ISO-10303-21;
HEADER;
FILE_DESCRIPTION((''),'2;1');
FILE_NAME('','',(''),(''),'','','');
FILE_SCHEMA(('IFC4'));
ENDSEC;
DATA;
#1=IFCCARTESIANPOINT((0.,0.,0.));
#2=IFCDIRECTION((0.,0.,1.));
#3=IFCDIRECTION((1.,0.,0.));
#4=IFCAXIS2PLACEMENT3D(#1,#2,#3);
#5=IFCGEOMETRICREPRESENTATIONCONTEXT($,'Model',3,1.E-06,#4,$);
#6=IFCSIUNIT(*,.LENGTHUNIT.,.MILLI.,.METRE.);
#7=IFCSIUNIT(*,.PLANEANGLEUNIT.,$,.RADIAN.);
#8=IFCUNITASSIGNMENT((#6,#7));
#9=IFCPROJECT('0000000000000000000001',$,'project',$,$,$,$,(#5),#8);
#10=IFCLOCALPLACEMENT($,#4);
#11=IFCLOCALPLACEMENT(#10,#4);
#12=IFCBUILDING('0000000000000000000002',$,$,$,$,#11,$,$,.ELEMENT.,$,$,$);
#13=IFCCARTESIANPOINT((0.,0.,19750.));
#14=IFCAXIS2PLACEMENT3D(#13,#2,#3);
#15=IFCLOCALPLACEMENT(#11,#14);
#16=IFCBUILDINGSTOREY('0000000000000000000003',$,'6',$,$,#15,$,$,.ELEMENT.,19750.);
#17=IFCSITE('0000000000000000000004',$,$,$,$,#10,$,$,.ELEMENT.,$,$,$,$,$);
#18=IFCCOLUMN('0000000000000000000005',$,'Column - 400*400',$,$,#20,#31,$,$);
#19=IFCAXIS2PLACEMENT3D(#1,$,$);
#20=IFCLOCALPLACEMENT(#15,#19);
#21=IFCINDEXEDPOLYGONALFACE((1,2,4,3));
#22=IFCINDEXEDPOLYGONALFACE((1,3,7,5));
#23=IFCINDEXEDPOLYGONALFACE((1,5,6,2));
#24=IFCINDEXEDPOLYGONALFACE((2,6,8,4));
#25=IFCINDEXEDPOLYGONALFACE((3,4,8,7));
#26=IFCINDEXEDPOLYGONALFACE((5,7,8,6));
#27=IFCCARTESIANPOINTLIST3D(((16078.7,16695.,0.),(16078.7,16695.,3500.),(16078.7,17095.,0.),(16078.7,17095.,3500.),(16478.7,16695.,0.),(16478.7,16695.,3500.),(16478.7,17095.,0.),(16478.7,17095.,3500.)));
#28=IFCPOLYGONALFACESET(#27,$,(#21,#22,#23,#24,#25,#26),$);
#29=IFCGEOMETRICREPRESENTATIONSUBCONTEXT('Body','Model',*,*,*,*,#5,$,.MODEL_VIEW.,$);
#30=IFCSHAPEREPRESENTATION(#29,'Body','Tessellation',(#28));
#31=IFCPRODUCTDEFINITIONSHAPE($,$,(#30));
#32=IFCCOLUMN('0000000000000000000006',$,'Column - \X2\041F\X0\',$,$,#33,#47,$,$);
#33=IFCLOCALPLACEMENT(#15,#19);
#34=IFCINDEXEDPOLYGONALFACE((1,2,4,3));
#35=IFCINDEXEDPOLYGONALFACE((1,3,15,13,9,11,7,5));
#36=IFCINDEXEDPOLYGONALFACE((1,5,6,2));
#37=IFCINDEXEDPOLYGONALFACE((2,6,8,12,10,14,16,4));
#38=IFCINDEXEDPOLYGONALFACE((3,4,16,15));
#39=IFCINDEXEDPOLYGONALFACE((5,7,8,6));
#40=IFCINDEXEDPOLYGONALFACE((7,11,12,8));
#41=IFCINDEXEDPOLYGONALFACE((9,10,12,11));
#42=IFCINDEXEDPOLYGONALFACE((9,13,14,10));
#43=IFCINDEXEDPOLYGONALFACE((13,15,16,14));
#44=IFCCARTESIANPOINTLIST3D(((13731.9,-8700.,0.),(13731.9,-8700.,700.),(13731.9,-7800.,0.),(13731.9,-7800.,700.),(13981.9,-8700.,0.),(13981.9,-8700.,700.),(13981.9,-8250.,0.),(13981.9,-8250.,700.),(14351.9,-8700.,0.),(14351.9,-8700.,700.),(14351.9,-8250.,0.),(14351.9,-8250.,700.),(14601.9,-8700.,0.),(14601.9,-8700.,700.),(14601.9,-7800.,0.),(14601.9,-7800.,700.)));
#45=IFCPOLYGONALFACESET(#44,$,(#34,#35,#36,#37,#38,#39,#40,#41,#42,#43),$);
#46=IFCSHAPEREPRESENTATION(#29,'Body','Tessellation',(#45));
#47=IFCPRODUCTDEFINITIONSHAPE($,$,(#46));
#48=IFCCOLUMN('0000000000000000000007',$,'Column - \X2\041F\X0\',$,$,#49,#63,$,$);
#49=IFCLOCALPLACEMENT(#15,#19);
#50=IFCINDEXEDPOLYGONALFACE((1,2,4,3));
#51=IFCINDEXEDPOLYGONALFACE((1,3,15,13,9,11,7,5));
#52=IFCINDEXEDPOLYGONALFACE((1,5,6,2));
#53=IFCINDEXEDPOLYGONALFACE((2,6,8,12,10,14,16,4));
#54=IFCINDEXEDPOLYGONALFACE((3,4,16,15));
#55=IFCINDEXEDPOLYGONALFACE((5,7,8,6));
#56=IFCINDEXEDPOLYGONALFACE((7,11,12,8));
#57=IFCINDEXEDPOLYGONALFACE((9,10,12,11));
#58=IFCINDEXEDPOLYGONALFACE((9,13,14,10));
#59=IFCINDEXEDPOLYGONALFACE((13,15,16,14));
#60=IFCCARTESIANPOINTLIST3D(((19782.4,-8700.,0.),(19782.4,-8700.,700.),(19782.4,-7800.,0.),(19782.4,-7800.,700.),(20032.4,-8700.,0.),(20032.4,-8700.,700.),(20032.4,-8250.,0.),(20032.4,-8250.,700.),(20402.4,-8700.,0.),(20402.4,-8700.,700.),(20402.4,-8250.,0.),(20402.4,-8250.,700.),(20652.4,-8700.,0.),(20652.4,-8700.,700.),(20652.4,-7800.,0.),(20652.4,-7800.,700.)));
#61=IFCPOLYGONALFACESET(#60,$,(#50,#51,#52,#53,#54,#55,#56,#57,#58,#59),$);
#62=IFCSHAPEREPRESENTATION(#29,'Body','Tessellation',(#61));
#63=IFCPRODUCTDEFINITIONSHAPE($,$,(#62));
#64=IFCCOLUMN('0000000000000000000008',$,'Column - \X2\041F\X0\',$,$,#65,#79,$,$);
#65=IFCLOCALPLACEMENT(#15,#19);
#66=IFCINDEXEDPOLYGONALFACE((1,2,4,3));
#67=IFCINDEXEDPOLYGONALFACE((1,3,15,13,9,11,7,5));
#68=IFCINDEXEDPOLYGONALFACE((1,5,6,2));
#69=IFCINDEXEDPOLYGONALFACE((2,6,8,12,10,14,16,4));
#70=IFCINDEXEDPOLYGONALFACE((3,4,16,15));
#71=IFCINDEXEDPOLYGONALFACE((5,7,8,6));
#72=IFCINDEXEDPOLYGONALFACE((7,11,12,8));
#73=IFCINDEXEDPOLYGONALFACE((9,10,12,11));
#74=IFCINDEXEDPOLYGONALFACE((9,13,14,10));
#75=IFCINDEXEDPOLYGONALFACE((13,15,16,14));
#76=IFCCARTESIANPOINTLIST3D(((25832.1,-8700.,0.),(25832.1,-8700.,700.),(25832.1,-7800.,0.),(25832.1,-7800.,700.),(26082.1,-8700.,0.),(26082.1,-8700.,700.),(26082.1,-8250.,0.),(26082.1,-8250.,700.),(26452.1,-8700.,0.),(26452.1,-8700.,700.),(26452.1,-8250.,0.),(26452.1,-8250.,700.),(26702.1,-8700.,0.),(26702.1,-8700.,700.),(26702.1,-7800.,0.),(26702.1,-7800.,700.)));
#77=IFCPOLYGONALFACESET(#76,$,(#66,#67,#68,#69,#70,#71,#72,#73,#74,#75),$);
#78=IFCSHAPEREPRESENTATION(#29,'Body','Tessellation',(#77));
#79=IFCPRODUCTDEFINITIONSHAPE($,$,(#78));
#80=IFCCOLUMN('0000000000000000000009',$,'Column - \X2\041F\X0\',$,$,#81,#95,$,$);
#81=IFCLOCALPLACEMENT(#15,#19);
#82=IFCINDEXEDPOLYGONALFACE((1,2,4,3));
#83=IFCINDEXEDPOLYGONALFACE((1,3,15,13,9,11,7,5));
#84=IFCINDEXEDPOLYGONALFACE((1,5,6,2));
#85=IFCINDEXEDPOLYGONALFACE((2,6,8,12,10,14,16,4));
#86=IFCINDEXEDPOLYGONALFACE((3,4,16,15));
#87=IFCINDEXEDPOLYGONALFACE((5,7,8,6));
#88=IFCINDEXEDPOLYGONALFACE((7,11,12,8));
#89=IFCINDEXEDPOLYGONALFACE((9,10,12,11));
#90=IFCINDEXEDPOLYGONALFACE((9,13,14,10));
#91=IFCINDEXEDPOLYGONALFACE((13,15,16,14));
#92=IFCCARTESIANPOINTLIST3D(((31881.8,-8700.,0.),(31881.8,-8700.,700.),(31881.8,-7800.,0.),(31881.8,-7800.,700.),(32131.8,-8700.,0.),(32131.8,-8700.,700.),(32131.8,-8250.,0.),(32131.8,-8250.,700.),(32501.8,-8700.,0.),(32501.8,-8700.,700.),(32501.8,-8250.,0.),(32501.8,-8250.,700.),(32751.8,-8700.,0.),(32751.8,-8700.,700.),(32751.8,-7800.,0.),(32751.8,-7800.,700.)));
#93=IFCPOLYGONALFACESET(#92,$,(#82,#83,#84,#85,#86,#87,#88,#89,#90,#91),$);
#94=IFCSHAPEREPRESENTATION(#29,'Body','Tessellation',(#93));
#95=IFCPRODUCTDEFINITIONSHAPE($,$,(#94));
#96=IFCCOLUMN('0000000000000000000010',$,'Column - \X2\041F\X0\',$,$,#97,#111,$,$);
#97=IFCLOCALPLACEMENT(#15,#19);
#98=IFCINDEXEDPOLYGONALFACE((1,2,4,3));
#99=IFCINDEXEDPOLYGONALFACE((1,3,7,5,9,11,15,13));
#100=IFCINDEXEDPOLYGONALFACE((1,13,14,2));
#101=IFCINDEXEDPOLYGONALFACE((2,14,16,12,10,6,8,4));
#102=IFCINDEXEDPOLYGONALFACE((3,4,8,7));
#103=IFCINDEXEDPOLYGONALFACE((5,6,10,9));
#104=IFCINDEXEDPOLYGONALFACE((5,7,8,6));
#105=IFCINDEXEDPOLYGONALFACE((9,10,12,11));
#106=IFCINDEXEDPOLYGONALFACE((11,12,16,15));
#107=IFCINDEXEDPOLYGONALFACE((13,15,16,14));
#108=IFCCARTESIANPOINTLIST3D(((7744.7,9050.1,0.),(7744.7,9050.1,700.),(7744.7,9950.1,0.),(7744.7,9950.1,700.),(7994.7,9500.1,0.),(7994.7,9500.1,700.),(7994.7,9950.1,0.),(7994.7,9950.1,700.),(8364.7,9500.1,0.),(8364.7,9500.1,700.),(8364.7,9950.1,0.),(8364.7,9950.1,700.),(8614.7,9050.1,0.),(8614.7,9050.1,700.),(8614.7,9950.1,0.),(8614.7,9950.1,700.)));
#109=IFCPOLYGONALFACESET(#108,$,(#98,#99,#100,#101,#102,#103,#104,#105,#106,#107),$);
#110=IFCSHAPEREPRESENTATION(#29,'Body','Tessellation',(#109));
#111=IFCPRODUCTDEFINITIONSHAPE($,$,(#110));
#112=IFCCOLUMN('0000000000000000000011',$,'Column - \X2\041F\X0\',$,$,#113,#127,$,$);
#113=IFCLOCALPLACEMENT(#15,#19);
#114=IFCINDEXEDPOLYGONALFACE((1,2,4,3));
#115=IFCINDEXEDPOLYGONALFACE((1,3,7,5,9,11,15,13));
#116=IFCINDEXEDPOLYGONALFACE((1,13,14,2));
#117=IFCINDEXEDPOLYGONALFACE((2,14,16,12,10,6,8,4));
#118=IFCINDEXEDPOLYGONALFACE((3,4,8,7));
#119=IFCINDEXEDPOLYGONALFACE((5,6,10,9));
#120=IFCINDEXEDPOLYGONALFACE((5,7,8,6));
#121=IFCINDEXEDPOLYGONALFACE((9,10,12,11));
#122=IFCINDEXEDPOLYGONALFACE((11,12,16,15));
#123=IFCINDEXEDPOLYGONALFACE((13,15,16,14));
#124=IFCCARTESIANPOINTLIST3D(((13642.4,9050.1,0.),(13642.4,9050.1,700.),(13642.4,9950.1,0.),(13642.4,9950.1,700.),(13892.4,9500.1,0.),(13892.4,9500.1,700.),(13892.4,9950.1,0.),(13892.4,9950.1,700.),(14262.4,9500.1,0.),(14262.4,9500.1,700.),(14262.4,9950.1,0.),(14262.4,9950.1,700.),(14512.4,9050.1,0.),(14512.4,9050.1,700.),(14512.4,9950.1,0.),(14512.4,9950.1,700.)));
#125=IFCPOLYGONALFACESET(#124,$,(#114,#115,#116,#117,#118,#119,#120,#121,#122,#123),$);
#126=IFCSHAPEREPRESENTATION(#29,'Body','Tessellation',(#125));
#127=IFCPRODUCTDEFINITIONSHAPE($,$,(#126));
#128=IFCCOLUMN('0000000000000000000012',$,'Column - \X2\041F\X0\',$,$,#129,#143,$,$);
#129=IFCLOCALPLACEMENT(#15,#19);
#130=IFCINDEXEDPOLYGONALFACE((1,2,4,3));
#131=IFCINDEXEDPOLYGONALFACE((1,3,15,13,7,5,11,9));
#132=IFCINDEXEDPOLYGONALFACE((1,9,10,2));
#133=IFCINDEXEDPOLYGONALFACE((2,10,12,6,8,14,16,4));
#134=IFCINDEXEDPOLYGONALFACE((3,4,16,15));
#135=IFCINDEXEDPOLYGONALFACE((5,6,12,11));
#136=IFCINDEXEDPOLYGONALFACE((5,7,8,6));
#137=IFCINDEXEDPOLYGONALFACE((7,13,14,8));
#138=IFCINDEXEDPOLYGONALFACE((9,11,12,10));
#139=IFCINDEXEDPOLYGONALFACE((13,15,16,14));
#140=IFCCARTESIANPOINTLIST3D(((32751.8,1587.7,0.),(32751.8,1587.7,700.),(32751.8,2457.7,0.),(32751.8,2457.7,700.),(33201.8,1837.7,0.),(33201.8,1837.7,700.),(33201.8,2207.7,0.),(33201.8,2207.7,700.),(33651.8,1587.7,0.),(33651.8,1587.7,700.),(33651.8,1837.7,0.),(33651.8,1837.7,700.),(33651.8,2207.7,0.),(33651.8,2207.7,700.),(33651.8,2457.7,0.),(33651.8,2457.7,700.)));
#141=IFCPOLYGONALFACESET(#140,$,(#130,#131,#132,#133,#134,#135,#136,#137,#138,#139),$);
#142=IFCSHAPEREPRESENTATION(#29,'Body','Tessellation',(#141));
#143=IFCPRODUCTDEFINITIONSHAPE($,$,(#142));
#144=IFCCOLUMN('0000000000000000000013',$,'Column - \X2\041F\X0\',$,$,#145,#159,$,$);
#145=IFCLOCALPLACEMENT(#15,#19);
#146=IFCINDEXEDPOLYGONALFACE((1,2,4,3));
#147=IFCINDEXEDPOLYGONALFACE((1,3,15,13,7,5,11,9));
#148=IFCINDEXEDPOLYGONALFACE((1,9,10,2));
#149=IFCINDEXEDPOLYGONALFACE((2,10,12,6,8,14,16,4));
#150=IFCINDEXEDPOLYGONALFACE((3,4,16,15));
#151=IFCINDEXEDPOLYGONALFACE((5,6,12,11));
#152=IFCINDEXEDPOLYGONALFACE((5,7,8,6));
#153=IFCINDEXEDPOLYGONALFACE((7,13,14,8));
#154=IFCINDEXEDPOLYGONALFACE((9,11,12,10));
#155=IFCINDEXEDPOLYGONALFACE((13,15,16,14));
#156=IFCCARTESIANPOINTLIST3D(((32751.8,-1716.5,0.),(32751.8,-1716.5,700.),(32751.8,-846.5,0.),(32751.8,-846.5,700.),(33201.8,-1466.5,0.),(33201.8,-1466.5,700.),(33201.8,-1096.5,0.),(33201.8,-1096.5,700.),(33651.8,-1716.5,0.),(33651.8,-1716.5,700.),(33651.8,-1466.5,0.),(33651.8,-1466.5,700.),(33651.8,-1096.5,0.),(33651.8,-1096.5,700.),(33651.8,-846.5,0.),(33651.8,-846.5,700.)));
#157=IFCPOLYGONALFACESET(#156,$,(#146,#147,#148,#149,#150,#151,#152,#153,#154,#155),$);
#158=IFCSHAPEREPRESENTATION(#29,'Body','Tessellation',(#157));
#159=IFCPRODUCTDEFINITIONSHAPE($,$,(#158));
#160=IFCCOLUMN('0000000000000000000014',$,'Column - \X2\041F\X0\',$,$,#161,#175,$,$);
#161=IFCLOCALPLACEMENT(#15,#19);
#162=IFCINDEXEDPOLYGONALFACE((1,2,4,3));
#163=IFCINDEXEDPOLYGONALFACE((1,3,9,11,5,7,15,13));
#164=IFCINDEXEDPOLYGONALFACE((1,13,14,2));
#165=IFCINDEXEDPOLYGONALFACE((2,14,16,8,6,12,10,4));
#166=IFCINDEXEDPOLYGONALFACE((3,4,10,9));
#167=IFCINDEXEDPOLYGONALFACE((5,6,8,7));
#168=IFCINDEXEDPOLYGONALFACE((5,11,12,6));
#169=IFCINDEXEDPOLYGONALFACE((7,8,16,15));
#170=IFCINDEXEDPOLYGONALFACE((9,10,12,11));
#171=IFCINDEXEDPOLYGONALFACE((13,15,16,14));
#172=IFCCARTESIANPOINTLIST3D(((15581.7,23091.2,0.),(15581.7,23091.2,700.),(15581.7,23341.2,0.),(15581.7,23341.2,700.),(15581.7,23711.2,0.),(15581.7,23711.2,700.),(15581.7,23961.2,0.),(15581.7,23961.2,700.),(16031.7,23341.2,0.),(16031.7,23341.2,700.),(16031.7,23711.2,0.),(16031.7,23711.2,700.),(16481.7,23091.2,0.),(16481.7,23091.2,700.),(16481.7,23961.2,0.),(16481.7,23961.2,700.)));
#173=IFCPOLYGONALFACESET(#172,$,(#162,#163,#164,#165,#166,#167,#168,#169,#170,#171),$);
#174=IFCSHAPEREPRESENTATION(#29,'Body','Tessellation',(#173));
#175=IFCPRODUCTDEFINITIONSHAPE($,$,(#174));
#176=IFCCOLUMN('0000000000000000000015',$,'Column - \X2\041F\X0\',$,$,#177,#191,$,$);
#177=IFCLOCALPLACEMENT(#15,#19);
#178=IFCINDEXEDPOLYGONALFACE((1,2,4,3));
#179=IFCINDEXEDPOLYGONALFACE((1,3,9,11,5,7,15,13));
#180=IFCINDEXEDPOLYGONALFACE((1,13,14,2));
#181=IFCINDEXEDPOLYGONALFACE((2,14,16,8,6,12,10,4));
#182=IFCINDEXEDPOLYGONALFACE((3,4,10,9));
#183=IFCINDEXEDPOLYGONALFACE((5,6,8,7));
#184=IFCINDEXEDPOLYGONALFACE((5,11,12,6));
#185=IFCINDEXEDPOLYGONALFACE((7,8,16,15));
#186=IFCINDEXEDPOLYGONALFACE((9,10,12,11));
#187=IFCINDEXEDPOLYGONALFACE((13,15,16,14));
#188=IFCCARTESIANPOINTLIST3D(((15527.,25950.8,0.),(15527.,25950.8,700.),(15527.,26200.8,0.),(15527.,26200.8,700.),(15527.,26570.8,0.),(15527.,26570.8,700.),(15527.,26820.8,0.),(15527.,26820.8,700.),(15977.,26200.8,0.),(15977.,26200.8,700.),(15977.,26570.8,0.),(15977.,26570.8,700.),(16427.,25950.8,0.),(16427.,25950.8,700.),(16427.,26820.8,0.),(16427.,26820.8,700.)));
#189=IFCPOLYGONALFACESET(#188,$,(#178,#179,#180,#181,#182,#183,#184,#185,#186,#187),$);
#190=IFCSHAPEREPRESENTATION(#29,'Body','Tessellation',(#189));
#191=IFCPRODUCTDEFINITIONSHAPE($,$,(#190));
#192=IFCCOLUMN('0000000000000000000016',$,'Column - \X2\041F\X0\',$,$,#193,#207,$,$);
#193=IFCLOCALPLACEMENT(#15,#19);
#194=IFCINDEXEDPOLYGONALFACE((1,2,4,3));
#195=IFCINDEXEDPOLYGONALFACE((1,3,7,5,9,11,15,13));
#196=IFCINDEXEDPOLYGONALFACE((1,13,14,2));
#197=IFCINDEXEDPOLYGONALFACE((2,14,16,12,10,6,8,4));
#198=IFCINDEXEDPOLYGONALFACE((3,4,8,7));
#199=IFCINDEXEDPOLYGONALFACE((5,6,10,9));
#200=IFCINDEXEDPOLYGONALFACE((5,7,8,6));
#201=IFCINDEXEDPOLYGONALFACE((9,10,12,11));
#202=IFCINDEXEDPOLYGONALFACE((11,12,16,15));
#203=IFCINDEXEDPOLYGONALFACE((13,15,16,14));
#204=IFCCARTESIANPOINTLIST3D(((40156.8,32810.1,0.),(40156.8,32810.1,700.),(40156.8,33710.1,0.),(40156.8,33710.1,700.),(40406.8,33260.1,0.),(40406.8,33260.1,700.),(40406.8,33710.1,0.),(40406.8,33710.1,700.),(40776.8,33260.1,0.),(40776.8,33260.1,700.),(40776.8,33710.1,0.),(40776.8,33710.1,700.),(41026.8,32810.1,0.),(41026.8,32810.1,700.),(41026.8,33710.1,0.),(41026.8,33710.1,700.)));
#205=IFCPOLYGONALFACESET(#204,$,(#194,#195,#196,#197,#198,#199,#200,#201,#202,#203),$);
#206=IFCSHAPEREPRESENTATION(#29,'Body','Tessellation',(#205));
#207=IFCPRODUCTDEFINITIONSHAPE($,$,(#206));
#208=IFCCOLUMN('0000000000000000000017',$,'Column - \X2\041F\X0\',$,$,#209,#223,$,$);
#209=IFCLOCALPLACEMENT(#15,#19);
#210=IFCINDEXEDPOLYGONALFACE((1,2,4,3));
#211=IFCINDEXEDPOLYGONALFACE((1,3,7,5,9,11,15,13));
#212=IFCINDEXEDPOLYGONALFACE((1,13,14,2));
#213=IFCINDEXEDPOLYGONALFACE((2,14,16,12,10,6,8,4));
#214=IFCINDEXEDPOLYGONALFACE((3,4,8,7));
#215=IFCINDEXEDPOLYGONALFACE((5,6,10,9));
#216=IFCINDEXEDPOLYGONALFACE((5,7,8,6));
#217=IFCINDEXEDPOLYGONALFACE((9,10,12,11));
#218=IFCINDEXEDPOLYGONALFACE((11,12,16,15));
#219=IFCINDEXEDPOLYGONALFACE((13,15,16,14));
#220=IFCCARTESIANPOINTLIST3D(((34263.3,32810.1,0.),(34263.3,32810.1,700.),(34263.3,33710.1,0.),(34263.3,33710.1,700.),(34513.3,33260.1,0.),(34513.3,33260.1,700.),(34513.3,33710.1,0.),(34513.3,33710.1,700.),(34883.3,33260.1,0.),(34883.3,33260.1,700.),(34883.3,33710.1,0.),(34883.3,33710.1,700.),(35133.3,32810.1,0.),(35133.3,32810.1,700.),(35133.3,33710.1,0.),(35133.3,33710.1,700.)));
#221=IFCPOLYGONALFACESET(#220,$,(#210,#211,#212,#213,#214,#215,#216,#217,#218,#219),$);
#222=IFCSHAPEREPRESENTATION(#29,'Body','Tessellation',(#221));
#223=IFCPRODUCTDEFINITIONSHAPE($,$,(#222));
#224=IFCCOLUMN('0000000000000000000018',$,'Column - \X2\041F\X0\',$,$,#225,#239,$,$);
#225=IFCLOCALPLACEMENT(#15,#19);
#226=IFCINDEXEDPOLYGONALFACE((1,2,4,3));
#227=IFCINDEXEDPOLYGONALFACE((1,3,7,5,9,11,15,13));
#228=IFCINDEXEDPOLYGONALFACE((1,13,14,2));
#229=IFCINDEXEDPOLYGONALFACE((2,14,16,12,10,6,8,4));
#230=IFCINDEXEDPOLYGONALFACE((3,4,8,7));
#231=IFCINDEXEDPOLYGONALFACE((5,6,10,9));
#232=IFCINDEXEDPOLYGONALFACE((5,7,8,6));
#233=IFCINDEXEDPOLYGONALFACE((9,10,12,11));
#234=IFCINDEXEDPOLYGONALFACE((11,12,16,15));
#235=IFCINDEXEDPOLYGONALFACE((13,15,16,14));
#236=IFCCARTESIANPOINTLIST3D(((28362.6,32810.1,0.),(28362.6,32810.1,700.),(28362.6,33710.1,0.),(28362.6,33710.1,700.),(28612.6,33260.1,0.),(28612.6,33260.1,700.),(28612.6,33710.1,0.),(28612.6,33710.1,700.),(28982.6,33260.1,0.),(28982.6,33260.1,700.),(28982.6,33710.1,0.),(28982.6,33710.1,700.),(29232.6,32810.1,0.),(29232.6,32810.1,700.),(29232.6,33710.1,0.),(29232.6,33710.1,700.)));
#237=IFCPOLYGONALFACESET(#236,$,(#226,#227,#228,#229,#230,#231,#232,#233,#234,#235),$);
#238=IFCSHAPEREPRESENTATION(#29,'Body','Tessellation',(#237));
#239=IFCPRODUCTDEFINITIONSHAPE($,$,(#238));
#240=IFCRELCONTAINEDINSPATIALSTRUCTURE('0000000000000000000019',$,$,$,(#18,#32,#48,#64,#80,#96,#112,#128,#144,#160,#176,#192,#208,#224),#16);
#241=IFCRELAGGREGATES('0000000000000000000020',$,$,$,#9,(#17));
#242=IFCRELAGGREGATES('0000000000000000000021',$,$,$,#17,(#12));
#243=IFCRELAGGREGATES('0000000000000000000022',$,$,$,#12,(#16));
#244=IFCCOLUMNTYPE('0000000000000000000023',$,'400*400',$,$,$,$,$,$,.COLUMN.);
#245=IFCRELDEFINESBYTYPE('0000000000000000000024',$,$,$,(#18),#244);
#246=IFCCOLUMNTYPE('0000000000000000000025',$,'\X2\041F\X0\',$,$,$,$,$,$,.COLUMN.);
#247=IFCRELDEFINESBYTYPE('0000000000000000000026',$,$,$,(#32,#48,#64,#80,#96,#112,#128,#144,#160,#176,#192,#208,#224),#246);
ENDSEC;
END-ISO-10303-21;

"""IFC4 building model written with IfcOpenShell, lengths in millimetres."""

from ifc_helpers import new_model, si_unit, frame, origin_with_axes, place, context, subcontext, project, spatial, line, indexed_curve, outline, extrude, source, transform, mapped, type_object, element, save


model = new_model("IFC4")

# Units and contexts
model_context = context("Model", 3, precision=1e-06, world=origin_with_axes())
body_context = subcontext(model_context, "Body", "Model", "MODEL_VIEW")
ifc_project = project(units=[si_unit("LENGTHUNIT", "METRE", prefix="MILLI"), si_unit("PLANEANGLEUNIT", "RADIAN")], contexts=[model_context])

# Site, building, storey
site_placement = place(None, origin_with_axes())
site = spatial("IfcSite", under=ifc_project, at=site_placement, CompositionType="ELEMENT")
building_placement = place(site_placement, origin_with_axes())
building = spatial("IfcBuilding", under=site, at=building_placement, CompositionType="ELEMENT")
storey_placement = place(building_placement, frame((0.0, 0.0, 19750.0), z_axis=(0.0, 0.0, 1.0), x_axis=(1.0, 0.0, 0.0)))
storey = spatial("IfcBuildingStorey", under=building, at=storey_placement, Name="6", CompositionType="ELEMENT", Elevation=19750.0)

# Columns
column_type_1 = type_object("IfcColumnType", Name="400*400", PredefinedType="COLUMN")
shared_shape_1 = source(origin_with_axes(), body_context, "Body", "SweptSolid", [
    extrude(outline(indexed_curve([(-200.0, -200.0), (200.0, -200.0), (200.0, 200.0), (-200.0, 200.0)], segments=[line(1, 2), line(2, 3), line(3, 4), line(4, 1)])), origin_with_axes(), (0.0, 0.0, 1.0), 3500.0),
])
column_placement = place(storey_placement, frame((16278.7, 16895.0, 0.0), z_axis=(0.0, 0.0, 1.0), x_axis=(1.0, 0.0, 0.0)))
element("IfcColumn", 1, at=column_placement, inside=storey, type_object=column_type_1, Name="Column - 400*400", context=body_context, shape_type="MappedRepresentation", body=[
    mapped(shared_shape_1, transform((0.0, 0.0, 0.0), x_axis=(1.0, 0.0, 0.0), y_axis=(0.0, 1.0, 0.0), z_axis=(0.0, 0.0, 1.0), scale=1.0)),
])
column_type_2 = type_object("IfcColumnType", Name="П", PredefinedType="COLUMN")
shared_shape_2 = source(origin_with_axes(), body_context, "Body", "SweptSolid", [
    extrude(outline(indexed_curve([(-450.0, -435.0), (450.0, -435.0), (450.0, -185.0), (0.0, -185.0), (0.0, 185.0), (450.0, 185.0), (450.0, 435.0), (-450.0, 435.0)], segments=[line(1, 2), line(2, 3), line(3, 4), line(4, 5), line(5, 6), line(6, 7), line(7, 8), line(8, 1)])), origin_with_axes(), (0.0, 0.0, 1.0), 700.0),
])
for number, where, z_axis, x_axis, name in (
    (2, (14166.9, -8250.0, 0.0), (0.0, 0.0, 1.0), (0.0, -1.0, 0.0), "Column - П"),
    (3, (20217.4, -8250.0, 0.0), (0.0, 0.0, 1.0), (0.0, -1.0, 0.0), "Column - П"),
    (4, (26267.1, -8250.0, 0.0), (0.0, 0.0, 1.0), (0.0, -1.0, 0.0), "Column - П"),
    (5, (32316.8, -8250.0, 0.0), (0.0, 0.0, 1.0), (0.0, -1.0, 0.0), "Column - П"),
    (6, (8179.7, 9500.1, 0.0), (0.0, 0.0, 1.0), (0.0, 1.0, 0.0), "Column - П"),
    (7, (14077.4, 9500.1, 0.0), (0.0, 0.0, 1.0), (0.0, 1.0, 0.0), "Column - П"),
    (8, (33201.8, 2022.7, 0.0), (0.0, 0.0, 1.0), (1.0, 0.0, 0.0), "Column - П"),
    (9, (33201.8, -1281.5, 0.0), (0.0, 0.0, 1.0), (1.0, 0.0, 0.0), "Column - П"),
    (10, (16031.7, 23526.2, 0.0), (0.0, 0.0, 1.0), (-1.0, 0.0, 0.0), "Column - П"),
    (11, (15977.0, 26385.8, 0.0), (0.0, 0.0, 1.0), (-1.0, 0.0, 0.0), "Column - П"),
    (12, (40591.8, 33260.1, 0.0), (0.0, 0.0, 1.0), (0.0, 1.0, 0.0), "Column - П"),
    (13, (34698.3, 33260.1, 0.0), (0.0, 0.0, 1.0), (0.0, 1.0, 0.0), "Column - П"),
    (14, (28797.6, 33260.1, 0.0), (0.0, 0.0, 1.0), (0.0, 1.0, 0.0), "Column - П"),
):
    element("IfcColumn", number, at=place(storey_placement, frame(where, z_axis=z_axis, x_axis=x_axis)), inside=storey, type_object=column_type_2, Name=name, context=body_context, shape_type="MappedRepresentation", body=[
        mapped(shared_shape_2, transform((0.0, 0.0, 0.0), x_axis=(1.0, 0.0, 0.0), y_axis=(0.0, 1.0, 0.0), z_axis=(0.0, 0.0, 1.0), scale=1.0)),
    ])

save(model, "model.ifc")
